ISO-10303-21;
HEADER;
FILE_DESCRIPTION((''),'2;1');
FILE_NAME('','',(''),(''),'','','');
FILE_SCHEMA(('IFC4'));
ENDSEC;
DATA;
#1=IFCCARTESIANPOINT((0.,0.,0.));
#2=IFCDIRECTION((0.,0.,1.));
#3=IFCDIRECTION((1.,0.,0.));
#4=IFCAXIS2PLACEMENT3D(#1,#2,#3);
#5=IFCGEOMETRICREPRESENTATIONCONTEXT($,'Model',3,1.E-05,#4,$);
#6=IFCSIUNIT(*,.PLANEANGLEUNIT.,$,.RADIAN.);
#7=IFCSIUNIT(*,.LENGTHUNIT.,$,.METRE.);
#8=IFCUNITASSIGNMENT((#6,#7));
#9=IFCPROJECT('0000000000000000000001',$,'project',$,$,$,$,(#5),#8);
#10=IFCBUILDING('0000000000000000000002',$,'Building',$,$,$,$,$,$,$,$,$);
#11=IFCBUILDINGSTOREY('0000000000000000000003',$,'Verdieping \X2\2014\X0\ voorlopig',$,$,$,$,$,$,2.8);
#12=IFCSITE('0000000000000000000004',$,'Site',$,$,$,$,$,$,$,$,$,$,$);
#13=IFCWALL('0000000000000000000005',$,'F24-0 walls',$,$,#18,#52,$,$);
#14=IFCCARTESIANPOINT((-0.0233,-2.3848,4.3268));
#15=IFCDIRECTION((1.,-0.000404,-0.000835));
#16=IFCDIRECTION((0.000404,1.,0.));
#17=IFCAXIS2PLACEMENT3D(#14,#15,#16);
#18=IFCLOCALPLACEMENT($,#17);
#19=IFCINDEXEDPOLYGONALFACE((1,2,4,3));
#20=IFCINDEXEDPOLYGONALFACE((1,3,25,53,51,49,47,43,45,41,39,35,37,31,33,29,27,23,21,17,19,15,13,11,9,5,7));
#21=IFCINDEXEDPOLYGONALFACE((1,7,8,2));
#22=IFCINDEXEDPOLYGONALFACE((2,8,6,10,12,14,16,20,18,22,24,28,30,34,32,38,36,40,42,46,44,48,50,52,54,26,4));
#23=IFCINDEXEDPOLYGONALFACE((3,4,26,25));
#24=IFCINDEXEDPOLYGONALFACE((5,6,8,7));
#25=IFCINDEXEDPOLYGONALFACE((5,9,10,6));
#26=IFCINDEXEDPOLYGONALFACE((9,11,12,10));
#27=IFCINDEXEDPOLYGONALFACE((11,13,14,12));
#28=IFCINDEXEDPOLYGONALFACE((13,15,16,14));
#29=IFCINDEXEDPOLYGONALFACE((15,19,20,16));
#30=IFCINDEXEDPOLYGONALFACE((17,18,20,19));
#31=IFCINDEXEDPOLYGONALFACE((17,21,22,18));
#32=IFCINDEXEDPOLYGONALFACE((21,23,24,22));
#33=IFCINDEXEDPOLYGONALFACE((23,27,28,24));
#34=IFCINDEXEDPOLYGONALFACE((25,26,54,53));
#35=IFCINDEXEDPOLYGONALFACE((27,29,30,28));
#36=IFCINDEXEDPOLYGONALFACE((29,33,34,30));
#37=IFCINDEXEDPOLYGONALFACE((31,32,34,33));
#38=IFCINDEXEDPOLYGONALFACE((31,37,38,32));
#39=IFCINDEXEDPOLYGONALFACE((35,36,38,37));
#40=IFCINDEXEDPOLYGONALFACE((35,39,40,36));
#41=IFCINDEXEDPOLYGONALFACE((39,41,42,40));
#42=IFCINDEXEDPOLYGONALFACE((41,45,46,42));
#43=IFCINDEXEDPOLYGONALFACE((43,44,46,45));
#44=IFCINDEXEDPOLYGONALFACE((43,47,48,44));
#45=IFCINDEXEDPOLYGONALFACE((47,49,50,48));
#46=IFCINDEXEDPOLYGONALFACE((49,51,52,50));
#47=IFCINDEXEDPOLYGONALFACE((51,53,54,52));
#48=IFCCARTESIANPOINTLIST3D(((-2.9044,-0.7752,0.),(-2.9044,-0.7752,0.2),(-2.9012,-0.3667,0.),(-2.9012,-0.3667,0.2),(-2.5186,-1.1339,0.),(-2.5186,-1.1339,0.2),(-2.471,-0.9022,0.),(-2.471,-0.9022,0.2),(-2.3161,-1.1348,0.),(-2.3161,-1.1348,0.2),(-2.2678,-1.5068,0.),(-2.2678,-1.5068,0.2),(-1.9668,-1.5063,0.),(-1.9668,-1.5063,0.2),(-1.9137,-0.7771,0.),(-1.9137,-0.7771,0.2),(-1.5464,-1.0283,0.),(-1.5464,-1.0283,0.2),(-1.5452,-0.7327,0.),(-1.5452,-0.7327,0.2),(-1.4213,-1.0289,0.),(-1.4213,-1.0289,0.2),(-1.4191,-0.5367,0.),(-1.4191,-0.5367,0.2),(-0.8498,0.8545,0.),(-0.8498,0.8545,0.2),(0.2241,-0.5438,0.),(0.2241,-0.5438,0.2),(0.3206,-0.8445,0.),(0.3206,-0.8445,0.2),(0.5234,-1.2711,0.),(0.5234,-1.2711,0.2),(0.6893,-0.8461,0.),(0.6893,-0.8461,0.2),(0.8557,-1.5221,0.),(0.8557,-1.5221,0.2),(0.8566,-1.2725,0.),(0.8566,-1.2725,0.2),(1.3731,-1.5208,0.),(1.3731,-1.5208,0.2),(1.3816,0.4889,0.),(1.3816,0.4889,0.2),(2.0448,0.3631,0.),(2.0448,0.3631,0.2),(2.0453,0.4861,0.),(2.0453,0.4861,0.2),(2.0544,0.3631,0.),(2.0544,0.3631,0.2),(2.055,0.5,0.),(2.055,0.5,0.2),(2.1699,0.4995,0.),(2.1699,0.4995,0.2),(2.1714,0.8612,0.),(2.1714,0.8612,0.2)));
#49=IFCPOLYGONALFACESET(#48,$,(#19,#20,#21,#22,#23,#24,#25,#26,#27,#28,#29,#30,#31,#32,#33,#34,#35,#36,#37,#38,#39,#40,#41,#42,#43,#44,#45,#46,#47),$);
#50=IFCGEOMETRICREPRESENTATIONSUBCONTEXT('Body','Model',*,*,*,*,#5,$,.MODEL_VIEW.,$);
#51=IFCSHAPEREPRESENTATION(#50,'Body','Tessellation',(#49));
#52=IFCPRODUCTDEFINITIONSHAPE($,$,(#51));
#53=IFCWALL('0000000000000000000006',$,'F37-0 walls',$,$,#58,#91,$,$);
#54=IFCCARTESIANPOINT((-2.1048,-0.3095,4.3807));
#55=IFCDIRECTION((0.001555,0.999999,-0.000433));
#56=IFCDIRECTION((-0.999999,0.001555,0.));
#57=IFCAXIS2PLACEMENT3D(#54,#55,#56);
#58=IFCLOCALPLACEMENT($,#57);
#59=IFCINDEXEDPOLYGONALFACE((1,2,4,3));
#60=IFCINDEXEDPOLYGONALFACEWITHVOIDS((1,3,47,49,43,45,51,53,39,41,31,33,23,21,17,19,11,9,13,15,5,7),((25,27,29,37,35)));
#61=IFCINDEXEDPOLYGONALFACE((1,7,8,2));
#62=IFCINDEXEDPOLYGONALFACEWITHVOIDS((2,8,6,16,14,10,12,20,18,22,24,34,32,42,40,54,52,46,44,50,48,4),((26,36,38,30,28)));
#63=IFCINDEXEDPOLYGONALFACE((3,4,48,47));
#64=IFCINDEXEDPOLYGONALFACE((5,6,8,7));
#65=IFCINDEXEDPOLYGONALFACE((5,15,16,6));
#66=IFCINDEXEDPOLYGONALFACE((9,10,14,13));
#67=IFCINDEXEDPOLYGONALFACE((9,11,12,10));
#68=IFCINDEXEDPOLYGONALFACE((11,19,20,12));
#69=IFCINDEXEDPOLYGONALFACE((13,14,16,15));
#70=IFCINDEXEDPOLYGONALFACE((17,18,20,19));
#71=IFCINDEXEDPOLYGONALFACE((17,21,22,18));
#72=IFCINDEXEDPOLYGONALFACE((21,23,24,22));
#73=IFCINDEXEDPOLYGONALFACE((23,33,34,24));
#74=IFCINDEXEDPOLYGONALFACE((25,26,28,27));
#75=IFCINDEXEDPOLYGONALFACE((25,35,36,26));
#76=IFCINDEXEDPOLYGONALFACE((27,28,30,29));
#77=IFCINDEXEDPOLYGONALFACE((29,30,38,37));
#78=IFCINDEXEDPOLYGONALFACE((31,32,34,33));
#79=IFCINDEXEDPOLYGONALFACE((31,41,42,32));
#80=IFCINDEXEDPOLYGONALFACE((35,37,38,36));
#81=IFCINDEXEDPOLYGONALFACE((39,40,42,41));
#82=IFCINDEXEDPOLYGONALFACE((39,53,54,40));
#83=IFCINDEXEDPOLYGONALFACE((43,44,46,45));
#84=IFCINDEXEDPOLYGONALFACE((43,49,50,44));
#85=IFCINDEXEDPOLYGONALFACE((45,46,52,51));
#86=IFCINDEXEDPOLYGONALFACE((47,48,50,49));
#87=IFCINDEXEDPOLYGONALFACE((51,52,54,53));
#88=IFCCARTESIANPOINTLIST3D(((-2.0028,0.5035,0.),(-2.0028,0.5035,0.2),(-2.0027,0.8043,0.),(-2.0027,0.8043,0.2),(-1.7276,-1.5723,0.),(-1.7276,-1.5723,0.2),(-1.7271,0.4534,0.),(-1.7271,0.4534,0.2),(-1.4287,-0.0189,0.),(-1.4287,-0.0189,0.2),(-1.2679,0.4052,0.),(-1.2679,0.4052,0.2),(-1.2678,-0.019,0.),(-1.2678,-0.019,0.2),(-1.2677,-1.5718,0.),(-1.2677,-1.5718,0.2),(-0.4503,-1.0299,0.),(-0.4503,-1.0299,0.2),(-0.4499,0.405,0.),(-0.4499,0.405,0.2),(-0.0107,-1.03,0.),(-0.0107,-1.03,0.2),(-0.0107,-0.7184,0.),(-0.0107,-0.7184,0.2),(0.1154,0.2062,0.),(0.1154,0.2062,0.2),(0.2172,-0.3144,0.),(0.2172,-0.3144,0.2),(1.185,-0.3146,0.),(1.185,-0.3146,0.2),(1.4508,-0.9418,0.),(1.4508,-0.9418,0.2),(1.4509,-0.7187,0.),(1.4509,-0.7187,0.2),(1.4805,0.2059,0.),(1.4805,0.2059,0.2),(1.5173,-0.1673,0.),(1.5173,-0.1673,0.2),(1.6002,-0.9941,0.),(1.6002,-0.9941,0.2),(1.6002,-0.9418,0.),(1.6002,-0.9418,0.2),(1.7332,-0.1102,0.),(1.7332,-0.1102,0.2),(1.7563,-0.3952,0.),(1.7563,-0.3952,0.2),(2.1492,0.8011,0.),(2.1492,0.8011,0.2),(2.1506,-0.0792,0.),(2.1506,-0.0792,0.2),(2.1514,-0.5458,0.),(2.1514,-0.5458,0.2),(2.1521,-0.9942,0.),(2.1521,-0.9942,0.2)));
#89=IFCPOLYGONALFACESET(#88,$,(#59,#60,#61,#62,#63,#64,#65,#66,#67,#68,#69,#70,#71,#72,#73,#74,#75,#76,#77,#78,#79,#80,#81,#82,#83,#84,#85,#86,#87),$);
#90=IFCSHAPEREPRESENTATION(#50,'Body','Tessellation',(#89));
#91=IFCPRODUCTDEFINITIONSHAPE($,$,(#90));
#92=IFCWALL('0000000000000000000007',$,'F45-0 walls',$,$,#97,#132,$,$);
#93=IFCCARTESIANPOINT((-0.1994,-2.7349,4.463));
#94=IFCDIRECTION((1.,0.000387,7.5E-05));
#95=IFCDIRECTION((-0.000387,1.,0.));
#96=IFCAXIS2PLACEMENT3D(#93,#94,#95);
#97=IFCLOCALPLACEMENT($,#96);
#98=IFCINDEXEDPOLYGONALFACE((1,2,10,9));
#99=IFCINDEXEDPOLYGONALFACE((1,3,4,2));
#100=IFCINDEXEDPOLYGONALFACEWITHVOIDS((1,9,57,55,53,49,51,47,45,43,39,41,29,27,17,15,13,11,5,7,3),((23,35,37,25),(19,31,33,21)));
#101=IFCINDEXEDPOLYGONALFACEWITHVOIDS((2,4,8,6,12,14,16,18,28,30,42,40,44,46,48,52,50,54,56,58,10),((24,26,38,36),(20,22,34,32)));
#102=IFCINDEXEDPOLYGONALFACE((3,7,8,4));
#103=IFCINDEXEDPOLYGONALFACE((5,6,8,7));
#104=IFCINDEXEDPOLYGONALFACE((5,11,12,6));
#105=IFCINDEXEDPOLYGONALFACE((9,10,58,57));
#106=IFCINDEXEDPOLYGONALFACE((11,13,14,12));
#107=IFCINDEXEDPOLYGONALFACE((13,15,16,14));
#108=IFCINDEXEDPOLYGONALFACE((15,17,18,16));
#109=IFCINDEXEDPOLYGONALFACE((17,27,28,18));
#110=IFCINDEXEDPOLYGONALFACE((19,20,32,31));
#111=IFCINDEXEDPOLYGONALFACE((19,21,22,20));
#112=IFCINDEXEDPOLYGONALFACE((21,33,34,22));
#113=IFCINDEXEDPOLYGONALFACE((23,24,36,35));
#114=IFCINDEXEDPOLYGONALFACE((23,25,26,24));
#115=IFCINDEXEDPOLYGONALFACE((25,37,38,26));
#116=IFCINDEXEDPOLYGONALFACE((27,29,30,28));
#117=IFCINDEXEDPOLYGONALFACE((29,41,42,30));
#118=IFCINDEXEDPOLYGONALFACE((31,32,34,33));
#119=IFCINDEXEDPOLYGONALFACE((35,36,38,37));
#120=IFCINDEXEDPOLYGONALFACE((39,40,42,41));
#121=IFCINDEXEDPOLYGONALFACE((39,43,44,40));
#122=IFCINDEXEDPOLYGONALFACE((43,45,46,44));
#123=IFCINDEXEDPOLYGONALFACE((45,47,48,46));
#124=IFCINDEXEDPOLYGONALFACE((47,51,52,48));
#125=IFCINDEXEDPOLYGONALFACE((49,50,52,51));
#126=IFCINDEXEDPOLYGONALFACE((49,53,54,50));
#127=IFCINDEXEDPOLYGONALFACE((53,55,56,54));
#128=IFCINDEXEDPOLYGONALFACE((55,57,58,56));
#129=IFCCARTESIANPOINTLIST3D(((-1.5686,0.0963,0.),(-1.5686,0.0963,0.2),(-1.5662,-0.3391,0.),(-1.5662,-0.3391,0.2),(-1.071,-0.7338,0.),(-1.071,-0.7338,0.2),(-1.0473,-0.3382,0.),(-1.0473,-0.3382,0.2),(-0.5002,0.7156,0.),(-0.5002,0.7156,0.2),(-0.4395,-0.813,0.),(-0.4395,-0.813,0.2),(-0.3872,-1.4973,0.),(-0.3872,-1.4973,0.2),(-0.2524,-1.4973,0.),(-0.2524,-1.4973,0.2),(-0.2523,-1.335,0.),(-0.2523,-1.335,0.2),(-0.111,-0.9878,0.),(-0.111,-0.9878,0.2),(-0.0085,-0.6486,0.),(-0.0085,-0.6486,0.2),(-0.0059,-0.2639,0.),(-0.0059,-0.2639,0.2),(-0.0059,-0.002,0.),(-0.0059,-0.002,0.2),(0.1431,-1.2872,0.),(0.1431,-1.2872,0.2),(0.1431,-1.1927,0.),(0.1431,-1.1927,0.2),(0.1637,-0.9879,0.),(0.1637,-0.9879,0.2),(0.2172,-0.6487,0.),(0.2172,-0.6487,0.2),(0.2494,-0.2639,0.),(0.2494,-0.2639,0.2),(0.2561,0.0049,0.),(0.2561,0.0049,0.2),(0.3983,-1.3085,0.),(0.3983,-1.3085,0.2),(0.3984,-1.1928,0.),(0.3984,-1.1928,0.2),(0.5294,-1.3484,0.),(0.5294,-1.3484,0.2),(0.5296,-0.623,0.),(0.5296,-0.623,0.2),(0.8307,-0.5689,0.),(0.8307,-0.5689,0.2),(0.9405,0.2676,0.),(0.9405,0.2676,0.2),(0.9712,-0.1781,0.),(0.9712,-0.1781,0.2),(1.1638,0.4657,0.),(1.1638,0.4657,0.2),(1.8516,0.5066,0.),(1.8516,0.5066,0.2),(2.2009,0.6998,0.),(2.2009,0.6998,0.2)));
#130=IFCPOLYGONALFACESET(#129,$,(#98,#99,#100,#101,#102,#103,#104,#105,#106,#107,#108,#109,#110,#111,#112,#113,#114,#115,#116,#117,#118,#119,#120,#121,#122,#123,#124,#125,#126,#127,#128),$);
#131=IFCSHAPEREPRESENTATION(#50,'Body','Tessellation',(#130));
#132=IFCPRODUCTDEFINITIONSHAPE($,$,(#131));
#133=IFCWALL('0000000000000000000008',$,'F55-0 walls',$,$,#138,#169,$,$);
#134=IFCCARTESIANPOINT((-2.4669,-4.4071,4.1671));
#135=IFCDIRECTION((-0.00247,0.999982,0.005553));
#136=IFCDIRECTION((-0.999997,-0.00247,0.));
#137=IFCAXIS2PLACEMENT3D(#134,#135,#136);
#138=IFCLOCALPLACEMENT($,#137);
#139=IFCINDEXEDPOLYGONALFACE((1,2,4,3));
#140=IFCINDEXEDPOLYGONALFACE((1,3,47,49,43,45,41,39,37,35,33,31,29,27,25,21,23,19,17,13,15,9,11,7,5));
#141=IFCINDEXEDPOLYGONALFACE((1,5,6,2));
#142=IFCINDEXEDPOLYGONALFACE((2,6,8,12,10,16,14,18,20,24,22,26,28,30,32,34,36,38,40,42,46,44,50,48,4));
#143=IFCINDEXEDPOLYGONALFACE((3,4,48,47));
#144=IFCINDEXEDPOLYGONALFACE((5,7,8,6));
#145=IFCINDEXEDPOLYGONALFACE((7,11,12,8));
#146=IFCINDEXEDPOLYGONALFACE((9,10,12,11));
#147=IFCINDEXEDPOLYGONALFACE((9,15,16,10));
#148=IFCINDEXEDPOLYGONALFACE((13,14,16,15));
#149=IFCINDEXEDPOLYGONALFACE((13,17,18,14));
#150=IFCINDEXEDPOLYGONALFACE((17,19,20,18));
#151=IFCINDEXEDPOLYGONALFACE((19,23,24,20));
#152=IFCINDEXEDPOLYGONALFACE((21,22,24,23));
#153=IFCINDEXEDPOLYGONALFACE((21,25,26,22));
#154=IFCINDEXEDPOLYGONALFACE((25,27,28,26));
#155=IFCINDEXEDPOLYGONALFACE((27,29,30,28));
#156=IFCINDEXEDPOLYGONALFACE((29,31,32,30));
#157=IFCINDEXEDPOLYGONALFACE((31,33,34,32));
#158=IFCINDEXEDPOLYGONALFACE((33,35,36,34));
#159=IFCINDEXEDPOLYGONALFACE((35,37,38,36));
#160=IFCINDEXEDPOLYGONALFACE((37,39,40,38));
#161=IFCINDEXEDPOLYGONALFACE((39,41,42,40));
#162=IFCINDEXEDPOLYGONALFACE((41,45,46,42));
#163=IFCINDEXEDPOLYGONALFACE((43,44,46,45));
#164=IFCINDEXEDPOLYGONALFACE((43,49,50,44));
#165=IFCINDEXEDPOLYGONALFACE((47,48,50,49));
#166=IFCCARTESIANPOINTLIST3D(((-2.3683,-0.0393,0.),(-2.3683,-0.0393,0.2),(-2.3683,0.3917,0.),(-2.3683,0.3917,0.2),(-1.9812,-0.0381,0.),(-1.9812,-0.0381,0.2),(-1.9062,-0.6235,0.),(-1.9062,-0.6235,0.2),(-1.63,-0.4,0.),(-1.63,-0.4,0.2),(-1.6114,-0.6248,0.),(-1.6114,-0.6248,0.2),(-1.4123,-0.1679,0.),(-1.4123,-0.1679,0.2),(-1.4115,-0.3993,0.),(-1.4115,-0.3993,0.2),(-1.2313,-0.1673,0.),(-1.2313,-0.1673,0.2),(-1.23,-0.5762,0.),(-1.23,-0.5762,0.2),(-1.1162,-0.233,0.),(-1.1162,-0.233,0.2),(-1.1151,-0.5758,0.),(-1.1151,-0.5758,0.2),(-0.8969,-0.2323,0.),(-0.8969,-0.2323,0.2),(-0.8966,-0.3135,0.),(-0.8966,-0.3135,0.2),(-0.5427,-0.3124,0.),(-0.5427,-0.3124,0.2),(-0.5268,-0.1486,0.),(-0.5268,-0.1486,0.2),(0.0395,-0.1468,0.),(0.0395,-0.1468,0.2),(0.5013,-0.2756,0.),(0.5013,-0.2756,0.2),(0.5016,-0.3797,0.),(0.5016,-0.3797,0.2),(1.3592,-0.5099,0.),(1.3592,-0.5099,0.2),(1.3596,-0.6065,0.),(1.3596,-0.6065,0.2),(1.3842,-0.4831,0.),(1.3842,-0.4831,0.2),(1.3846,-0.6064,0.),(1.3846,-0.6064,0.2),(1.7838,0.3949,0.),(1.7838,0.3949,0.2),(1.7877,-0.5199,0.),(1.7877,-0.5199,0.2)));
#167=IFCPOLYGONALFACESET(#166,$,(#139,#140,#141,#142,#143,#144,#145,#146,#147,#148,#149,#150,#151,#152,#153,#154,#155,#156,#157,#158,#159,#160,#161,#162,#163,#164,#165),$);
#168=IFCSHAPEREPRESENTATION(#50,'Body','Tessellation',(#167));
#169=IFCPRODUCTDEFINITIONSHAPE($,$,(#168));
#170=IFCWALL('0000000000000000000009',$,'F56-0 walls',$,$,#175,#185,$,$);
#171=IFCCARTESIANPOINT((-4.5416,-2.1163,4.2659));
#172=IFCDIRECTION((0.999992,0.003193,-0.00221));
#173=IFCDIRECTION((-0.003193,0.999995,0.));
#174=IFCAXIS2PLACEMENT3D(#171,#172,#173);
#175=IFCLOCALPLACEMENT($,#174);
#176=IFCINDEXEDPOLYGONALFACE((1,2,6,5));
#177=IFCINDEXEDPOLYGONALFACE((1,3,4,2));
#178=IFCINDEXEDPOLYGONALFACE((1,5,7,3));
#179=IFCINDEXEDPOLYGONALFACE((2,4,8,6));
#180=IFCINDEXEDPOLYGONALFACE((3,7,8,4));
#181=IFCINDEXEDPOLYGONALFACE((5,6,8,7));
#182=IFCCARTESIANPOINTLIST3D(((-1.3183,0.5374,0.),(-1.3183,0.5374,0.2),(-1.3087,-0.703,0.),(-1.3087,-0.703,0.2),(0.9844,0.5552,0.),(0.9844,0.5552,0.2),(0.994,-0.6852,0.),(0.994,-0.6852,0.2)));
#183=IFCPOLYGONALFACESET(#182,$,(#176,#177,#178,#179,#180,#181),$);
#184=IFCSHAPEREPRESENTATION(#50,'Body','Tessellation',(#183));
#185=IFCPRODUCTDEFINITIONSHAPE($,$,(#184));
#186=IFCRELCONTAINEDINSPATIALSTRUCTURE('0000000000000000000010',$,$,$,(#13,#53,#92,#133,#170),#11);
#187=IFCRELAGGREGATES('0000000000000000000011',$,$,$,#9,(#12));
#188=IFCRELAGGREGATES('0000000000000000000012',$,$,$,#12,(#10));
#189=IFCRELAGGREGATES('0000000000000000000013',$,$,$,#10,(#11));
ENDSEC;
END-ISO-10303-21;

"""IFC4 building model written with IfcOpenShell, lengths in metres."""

from ifc_helpers import new_model, si_unit, frame, origin_with_axes, place, context, subcontext, project, spatial, polyline, outline, extrude, element, save


model = new_model("IFC4")

# Units and contexts
model_context = context("Model", 3, precision=1e-05, world=origin_with_axes())
body_context = subcontext(model_context, "Body", "Model", "MODEL_VIEW")
ifc_project = project(units=[si_unit("PLANEANGLEUNIT", "RADIAN"), si_unit("LENGTHUNIT", "METRE")], contexts=[model_context])

# Site, building, storey
site = spatial("IfcSite", under=ifc_project, Name="Site")
building = spatial("IfcBuilding", under=site, Name="Building")
storey = spatial("IfcBuildingStorey", under=building, Name="Verdieping — voorlopig", Elevation=2.8)

# Wall
wall_1_placement = place(None, frame((-0.0233, -2.3848, 4.3268), z_axis=(1.0, -0.000404, -0.000835), x_axis=(0.000404, 1.0, 0.0)))
element("IfcWall", 1, at=wall_1_placement, inside=storey, Name="F24-0 walls", context=body_context, shape_type="SweptSolid", body=[
    extrude(outline(polyline([(0.8557, -1.5221), (1.3731, -1.5208), (1.3816, 0.4889), (2.0453, 0.4861), (2.0448, 0.3631), (2.0544, 0.3631), (2.055, 0.5), (2.1699, 0.4995), (2.1714, 0.8612), (-0.8498, 0.8545), (-2.9012, -0.3667), (-2.9044, -0.7752), (-2.471, -0.9022), (-2.5186, -1.1339), (-2.3161, -1.1348), (-2.2678, -1.5068), (-1.9668, -1.5063), (-1.9137, -0.7771), (-1.5452, -0.7327), (-1.5464, -1.0283), (-1.4213, -1.0289), (-1.4191, -0.5367), (0.2241, -0.5438), (0.3206, -0.8445), (0.6893, -0.8461), (0.5234, -1.2711), (0.8566, -1.2725), (0.8557, -1.5221)])), origin_with_axes(), (0.0, 0.0, 1.0), 0.2),
])

# Wall, opening
wall_2_placement = place(None, frame((-2.1048, -0.3095, 4.3807), z_axis=(0.001555, 0.999999, -0.000433), x_axis=(-0.999999, 0.001555, 0.0)))
wall_2 = element("IfcWall", 2, at=wall_2_placement, inside=storey, Name="F37-0 walls", context=body_context, shape_type="SweptSolid", body=[
    extrude(outline(polyline([(-1.7276, -1.5723), (-1.2677, -1.5718), (-1.2678, -0.019), (-1.4287, -0.0189), (-1.2679, 0.4052), (-0.4499, 0.405), (-0.4503, -1.0299), (-0.0107, -1.03), (-0.0107, -0.7184), (1.4509, -0.7187), (1.4508, -0.9418), (1.6002, -0.9418), (1.6002, -0.9941), (2.1521, -0.9942), (2.1514, -0.5458), (1.7563, -0.3952), (1.7332, -0.1102), (2.1506, -0.0792), (2.1492, 0.8011), (-2.0027, 0.8043), (-2.0028, 0.5035), (-1.7271, 0.4534), (-1.7276, -1.5723)])), origin_with_axes(), (0.0, 0.0, 1.0), 0.2),
])
opening_1_placement = place(wall_2_placement, frame((0.0, 0.0, -0.05), z_axis=(0.0, 0.0, 1.0), x_axis=(1.0, 0.0, 0.0)))
element("IfcOpeningElement", 3, at=opening_1_placement, cuts=wall_2, PredefinedType="OPENING", context=body_context, shape_type="SweptSolid", body=[
    extrude(outline(polyline([(1.185, -0.3146), (0.2172, -0.3144), (0.1154, 0.2062), (1.4805, 0.2059), (1.5173, -0.1673), (1.185, -0.3146)])), origin_with_axes(), (0.0, 0.0, 1.0), 0.3),
])

# Wall, openings
wall_3_placement = place(None, frame((-0.1994, -2.7349, 4.463), z_axis=(1.0, 0.000387, 0.000075), x_axis=(-0.000387, 1.0, 0.0)))
wall_3 = element("IfcWall", 4, at=wall_3_placement, inside=storey, Name="F45-0 walls", context=body_context, shape_type="SweptSolid", body=[
    extrude(outline(polyline([(-0.3872, -1.4973), (-0.2524, -1.4973), (-0.2523, -1.335), (0.1431, -1.2872), (0.1431, -1.1927), (0.3984, -1.1928), (0.3983, -1.3085), (0.5294, -1.3484), (0.5296, -0.623), (0.8307, -0.5689), (0.9712, -0.1781), (0.9405, 0.2676), (1.1638, 0.4657), (1.8516, 0.5066), (2.2009, 0.6998), (-0.5002, 0.7156), (-1.5686, 0.0963), (-1.5662, -0.3391), (-1.0473, -0.3382), (-1.071, -0.7338), (-0.4395, -0.813), (-0.3872, -1.4973)])), origin_with_axes(), (0.0, 0.0, 1.0), 0.2),
])
opening_2_placement = place(wall_3_placement, frame((0.0, 0.0, -0.05), z_axis=(0.0, 0.0, 1.0), x_axis=(1.0, 0.0, 0.0)))
element("IfcOpeningElement", 5, at=opening_2_placement, cuts=wall_3, PredefinedType="OPENING", context=body_context, shape_type="SweptSolid", body=[
    extrude(outline(polyline([(-0.0085, -0.6486), (0.2172, -0.6487), (0.1637, -0.9879), (-0.111, -0.9878), (-0.0085, -0.6486)])), origin_with_axes(), (0.0, 0.0, 1.0), 0.3),
])
opening_3_placement = place(wall_3_placement, frame((0.0, 0.0, -0.05), z_axis=(0.0, 0.0, 1.0), x_axis=(1.0, 0.0, 0.0)))
element("IfcOpeningElement", 6, at=opening_3_placement, cuts=wall_3, PredefinedType="OPENING", context=body_context, shape_type="SweptSolid", body=[
    extrude(outline(polyline([(-0.0059, -0.002), (0.2561, 0.0049), (0.2494, -0.2639), (-0.0059, -0.2639), (-0.0059, -0.002)])), origin_with_axes(), (0.0, 0.0, 1.0), 0.3),
])

# Walls
wall_4_placement = place(None, frame((-2.4669, -4.4071, 4.1671), z_axis=(-0.00247, 0.999982, 0.005553), x_axis=(-0.999997, -0.00247, 0.0)))
element("IfcWall", 7, at=wall_4_placement, inside=storey, Name="F55-0 walls", context=body_context, shape_type="SweptSolid", body=[
    extrude(outline(polyline([(-1.9062, -0.6235), (-1.6114, -0.6248), (-1.63, -0.4), (-1.4115, -0.3993), (-1.4123, -0.1679), (-1.2313, -0.1673), (-1.23, -0.5762), (-1.1151, -0.5758), (-1.1162, -0.233), (-0.8969, -0.2323), (-0.8966, -0.3135), (-0.5427, -0.3124), (-0.5268, -0.1486), (0.0395, -0.1468), (0.5013, -0.2756), (0.5016, -0.3797), (1.3592, -0.5099), (1.3596, -0.6065), (1.3846, -0.6064), (1.3842, -0.4831), (1.7877, -0.5199), (1.7838, 0.3949), (-2.3683, 0.3917), (-2.3683, -0.0393), (-1.9812, -0.0381), (-1.9062, -0.6235)])), origin_with_axes(), (0.0, 0.0, 1.0), 0.2),
])
wall_5_placement = place(None, frame((-4.5416, -2.1163, 4.2659), z_axis=(0.999992, 0.003193, -0.00221), x_axis=(-0.003193, 0.999995, 0.0)))
element("IfcWall", 8, at=wall_5_placement, inside=storey, Name="F56-0 walls", context=body_context, shape_type="SweptSolid", body=[
    extrude(outline(polyline([(-1.3087, -0.703), (0.994, -0.6852), (0.9844, 0.5552), (-1.3183, 0.5374), (-1.3087, -0.703)])), origin_with_axes(), (0.0, 0.0, 1.0), 0.2),
])

save(model, "model.ifc")
